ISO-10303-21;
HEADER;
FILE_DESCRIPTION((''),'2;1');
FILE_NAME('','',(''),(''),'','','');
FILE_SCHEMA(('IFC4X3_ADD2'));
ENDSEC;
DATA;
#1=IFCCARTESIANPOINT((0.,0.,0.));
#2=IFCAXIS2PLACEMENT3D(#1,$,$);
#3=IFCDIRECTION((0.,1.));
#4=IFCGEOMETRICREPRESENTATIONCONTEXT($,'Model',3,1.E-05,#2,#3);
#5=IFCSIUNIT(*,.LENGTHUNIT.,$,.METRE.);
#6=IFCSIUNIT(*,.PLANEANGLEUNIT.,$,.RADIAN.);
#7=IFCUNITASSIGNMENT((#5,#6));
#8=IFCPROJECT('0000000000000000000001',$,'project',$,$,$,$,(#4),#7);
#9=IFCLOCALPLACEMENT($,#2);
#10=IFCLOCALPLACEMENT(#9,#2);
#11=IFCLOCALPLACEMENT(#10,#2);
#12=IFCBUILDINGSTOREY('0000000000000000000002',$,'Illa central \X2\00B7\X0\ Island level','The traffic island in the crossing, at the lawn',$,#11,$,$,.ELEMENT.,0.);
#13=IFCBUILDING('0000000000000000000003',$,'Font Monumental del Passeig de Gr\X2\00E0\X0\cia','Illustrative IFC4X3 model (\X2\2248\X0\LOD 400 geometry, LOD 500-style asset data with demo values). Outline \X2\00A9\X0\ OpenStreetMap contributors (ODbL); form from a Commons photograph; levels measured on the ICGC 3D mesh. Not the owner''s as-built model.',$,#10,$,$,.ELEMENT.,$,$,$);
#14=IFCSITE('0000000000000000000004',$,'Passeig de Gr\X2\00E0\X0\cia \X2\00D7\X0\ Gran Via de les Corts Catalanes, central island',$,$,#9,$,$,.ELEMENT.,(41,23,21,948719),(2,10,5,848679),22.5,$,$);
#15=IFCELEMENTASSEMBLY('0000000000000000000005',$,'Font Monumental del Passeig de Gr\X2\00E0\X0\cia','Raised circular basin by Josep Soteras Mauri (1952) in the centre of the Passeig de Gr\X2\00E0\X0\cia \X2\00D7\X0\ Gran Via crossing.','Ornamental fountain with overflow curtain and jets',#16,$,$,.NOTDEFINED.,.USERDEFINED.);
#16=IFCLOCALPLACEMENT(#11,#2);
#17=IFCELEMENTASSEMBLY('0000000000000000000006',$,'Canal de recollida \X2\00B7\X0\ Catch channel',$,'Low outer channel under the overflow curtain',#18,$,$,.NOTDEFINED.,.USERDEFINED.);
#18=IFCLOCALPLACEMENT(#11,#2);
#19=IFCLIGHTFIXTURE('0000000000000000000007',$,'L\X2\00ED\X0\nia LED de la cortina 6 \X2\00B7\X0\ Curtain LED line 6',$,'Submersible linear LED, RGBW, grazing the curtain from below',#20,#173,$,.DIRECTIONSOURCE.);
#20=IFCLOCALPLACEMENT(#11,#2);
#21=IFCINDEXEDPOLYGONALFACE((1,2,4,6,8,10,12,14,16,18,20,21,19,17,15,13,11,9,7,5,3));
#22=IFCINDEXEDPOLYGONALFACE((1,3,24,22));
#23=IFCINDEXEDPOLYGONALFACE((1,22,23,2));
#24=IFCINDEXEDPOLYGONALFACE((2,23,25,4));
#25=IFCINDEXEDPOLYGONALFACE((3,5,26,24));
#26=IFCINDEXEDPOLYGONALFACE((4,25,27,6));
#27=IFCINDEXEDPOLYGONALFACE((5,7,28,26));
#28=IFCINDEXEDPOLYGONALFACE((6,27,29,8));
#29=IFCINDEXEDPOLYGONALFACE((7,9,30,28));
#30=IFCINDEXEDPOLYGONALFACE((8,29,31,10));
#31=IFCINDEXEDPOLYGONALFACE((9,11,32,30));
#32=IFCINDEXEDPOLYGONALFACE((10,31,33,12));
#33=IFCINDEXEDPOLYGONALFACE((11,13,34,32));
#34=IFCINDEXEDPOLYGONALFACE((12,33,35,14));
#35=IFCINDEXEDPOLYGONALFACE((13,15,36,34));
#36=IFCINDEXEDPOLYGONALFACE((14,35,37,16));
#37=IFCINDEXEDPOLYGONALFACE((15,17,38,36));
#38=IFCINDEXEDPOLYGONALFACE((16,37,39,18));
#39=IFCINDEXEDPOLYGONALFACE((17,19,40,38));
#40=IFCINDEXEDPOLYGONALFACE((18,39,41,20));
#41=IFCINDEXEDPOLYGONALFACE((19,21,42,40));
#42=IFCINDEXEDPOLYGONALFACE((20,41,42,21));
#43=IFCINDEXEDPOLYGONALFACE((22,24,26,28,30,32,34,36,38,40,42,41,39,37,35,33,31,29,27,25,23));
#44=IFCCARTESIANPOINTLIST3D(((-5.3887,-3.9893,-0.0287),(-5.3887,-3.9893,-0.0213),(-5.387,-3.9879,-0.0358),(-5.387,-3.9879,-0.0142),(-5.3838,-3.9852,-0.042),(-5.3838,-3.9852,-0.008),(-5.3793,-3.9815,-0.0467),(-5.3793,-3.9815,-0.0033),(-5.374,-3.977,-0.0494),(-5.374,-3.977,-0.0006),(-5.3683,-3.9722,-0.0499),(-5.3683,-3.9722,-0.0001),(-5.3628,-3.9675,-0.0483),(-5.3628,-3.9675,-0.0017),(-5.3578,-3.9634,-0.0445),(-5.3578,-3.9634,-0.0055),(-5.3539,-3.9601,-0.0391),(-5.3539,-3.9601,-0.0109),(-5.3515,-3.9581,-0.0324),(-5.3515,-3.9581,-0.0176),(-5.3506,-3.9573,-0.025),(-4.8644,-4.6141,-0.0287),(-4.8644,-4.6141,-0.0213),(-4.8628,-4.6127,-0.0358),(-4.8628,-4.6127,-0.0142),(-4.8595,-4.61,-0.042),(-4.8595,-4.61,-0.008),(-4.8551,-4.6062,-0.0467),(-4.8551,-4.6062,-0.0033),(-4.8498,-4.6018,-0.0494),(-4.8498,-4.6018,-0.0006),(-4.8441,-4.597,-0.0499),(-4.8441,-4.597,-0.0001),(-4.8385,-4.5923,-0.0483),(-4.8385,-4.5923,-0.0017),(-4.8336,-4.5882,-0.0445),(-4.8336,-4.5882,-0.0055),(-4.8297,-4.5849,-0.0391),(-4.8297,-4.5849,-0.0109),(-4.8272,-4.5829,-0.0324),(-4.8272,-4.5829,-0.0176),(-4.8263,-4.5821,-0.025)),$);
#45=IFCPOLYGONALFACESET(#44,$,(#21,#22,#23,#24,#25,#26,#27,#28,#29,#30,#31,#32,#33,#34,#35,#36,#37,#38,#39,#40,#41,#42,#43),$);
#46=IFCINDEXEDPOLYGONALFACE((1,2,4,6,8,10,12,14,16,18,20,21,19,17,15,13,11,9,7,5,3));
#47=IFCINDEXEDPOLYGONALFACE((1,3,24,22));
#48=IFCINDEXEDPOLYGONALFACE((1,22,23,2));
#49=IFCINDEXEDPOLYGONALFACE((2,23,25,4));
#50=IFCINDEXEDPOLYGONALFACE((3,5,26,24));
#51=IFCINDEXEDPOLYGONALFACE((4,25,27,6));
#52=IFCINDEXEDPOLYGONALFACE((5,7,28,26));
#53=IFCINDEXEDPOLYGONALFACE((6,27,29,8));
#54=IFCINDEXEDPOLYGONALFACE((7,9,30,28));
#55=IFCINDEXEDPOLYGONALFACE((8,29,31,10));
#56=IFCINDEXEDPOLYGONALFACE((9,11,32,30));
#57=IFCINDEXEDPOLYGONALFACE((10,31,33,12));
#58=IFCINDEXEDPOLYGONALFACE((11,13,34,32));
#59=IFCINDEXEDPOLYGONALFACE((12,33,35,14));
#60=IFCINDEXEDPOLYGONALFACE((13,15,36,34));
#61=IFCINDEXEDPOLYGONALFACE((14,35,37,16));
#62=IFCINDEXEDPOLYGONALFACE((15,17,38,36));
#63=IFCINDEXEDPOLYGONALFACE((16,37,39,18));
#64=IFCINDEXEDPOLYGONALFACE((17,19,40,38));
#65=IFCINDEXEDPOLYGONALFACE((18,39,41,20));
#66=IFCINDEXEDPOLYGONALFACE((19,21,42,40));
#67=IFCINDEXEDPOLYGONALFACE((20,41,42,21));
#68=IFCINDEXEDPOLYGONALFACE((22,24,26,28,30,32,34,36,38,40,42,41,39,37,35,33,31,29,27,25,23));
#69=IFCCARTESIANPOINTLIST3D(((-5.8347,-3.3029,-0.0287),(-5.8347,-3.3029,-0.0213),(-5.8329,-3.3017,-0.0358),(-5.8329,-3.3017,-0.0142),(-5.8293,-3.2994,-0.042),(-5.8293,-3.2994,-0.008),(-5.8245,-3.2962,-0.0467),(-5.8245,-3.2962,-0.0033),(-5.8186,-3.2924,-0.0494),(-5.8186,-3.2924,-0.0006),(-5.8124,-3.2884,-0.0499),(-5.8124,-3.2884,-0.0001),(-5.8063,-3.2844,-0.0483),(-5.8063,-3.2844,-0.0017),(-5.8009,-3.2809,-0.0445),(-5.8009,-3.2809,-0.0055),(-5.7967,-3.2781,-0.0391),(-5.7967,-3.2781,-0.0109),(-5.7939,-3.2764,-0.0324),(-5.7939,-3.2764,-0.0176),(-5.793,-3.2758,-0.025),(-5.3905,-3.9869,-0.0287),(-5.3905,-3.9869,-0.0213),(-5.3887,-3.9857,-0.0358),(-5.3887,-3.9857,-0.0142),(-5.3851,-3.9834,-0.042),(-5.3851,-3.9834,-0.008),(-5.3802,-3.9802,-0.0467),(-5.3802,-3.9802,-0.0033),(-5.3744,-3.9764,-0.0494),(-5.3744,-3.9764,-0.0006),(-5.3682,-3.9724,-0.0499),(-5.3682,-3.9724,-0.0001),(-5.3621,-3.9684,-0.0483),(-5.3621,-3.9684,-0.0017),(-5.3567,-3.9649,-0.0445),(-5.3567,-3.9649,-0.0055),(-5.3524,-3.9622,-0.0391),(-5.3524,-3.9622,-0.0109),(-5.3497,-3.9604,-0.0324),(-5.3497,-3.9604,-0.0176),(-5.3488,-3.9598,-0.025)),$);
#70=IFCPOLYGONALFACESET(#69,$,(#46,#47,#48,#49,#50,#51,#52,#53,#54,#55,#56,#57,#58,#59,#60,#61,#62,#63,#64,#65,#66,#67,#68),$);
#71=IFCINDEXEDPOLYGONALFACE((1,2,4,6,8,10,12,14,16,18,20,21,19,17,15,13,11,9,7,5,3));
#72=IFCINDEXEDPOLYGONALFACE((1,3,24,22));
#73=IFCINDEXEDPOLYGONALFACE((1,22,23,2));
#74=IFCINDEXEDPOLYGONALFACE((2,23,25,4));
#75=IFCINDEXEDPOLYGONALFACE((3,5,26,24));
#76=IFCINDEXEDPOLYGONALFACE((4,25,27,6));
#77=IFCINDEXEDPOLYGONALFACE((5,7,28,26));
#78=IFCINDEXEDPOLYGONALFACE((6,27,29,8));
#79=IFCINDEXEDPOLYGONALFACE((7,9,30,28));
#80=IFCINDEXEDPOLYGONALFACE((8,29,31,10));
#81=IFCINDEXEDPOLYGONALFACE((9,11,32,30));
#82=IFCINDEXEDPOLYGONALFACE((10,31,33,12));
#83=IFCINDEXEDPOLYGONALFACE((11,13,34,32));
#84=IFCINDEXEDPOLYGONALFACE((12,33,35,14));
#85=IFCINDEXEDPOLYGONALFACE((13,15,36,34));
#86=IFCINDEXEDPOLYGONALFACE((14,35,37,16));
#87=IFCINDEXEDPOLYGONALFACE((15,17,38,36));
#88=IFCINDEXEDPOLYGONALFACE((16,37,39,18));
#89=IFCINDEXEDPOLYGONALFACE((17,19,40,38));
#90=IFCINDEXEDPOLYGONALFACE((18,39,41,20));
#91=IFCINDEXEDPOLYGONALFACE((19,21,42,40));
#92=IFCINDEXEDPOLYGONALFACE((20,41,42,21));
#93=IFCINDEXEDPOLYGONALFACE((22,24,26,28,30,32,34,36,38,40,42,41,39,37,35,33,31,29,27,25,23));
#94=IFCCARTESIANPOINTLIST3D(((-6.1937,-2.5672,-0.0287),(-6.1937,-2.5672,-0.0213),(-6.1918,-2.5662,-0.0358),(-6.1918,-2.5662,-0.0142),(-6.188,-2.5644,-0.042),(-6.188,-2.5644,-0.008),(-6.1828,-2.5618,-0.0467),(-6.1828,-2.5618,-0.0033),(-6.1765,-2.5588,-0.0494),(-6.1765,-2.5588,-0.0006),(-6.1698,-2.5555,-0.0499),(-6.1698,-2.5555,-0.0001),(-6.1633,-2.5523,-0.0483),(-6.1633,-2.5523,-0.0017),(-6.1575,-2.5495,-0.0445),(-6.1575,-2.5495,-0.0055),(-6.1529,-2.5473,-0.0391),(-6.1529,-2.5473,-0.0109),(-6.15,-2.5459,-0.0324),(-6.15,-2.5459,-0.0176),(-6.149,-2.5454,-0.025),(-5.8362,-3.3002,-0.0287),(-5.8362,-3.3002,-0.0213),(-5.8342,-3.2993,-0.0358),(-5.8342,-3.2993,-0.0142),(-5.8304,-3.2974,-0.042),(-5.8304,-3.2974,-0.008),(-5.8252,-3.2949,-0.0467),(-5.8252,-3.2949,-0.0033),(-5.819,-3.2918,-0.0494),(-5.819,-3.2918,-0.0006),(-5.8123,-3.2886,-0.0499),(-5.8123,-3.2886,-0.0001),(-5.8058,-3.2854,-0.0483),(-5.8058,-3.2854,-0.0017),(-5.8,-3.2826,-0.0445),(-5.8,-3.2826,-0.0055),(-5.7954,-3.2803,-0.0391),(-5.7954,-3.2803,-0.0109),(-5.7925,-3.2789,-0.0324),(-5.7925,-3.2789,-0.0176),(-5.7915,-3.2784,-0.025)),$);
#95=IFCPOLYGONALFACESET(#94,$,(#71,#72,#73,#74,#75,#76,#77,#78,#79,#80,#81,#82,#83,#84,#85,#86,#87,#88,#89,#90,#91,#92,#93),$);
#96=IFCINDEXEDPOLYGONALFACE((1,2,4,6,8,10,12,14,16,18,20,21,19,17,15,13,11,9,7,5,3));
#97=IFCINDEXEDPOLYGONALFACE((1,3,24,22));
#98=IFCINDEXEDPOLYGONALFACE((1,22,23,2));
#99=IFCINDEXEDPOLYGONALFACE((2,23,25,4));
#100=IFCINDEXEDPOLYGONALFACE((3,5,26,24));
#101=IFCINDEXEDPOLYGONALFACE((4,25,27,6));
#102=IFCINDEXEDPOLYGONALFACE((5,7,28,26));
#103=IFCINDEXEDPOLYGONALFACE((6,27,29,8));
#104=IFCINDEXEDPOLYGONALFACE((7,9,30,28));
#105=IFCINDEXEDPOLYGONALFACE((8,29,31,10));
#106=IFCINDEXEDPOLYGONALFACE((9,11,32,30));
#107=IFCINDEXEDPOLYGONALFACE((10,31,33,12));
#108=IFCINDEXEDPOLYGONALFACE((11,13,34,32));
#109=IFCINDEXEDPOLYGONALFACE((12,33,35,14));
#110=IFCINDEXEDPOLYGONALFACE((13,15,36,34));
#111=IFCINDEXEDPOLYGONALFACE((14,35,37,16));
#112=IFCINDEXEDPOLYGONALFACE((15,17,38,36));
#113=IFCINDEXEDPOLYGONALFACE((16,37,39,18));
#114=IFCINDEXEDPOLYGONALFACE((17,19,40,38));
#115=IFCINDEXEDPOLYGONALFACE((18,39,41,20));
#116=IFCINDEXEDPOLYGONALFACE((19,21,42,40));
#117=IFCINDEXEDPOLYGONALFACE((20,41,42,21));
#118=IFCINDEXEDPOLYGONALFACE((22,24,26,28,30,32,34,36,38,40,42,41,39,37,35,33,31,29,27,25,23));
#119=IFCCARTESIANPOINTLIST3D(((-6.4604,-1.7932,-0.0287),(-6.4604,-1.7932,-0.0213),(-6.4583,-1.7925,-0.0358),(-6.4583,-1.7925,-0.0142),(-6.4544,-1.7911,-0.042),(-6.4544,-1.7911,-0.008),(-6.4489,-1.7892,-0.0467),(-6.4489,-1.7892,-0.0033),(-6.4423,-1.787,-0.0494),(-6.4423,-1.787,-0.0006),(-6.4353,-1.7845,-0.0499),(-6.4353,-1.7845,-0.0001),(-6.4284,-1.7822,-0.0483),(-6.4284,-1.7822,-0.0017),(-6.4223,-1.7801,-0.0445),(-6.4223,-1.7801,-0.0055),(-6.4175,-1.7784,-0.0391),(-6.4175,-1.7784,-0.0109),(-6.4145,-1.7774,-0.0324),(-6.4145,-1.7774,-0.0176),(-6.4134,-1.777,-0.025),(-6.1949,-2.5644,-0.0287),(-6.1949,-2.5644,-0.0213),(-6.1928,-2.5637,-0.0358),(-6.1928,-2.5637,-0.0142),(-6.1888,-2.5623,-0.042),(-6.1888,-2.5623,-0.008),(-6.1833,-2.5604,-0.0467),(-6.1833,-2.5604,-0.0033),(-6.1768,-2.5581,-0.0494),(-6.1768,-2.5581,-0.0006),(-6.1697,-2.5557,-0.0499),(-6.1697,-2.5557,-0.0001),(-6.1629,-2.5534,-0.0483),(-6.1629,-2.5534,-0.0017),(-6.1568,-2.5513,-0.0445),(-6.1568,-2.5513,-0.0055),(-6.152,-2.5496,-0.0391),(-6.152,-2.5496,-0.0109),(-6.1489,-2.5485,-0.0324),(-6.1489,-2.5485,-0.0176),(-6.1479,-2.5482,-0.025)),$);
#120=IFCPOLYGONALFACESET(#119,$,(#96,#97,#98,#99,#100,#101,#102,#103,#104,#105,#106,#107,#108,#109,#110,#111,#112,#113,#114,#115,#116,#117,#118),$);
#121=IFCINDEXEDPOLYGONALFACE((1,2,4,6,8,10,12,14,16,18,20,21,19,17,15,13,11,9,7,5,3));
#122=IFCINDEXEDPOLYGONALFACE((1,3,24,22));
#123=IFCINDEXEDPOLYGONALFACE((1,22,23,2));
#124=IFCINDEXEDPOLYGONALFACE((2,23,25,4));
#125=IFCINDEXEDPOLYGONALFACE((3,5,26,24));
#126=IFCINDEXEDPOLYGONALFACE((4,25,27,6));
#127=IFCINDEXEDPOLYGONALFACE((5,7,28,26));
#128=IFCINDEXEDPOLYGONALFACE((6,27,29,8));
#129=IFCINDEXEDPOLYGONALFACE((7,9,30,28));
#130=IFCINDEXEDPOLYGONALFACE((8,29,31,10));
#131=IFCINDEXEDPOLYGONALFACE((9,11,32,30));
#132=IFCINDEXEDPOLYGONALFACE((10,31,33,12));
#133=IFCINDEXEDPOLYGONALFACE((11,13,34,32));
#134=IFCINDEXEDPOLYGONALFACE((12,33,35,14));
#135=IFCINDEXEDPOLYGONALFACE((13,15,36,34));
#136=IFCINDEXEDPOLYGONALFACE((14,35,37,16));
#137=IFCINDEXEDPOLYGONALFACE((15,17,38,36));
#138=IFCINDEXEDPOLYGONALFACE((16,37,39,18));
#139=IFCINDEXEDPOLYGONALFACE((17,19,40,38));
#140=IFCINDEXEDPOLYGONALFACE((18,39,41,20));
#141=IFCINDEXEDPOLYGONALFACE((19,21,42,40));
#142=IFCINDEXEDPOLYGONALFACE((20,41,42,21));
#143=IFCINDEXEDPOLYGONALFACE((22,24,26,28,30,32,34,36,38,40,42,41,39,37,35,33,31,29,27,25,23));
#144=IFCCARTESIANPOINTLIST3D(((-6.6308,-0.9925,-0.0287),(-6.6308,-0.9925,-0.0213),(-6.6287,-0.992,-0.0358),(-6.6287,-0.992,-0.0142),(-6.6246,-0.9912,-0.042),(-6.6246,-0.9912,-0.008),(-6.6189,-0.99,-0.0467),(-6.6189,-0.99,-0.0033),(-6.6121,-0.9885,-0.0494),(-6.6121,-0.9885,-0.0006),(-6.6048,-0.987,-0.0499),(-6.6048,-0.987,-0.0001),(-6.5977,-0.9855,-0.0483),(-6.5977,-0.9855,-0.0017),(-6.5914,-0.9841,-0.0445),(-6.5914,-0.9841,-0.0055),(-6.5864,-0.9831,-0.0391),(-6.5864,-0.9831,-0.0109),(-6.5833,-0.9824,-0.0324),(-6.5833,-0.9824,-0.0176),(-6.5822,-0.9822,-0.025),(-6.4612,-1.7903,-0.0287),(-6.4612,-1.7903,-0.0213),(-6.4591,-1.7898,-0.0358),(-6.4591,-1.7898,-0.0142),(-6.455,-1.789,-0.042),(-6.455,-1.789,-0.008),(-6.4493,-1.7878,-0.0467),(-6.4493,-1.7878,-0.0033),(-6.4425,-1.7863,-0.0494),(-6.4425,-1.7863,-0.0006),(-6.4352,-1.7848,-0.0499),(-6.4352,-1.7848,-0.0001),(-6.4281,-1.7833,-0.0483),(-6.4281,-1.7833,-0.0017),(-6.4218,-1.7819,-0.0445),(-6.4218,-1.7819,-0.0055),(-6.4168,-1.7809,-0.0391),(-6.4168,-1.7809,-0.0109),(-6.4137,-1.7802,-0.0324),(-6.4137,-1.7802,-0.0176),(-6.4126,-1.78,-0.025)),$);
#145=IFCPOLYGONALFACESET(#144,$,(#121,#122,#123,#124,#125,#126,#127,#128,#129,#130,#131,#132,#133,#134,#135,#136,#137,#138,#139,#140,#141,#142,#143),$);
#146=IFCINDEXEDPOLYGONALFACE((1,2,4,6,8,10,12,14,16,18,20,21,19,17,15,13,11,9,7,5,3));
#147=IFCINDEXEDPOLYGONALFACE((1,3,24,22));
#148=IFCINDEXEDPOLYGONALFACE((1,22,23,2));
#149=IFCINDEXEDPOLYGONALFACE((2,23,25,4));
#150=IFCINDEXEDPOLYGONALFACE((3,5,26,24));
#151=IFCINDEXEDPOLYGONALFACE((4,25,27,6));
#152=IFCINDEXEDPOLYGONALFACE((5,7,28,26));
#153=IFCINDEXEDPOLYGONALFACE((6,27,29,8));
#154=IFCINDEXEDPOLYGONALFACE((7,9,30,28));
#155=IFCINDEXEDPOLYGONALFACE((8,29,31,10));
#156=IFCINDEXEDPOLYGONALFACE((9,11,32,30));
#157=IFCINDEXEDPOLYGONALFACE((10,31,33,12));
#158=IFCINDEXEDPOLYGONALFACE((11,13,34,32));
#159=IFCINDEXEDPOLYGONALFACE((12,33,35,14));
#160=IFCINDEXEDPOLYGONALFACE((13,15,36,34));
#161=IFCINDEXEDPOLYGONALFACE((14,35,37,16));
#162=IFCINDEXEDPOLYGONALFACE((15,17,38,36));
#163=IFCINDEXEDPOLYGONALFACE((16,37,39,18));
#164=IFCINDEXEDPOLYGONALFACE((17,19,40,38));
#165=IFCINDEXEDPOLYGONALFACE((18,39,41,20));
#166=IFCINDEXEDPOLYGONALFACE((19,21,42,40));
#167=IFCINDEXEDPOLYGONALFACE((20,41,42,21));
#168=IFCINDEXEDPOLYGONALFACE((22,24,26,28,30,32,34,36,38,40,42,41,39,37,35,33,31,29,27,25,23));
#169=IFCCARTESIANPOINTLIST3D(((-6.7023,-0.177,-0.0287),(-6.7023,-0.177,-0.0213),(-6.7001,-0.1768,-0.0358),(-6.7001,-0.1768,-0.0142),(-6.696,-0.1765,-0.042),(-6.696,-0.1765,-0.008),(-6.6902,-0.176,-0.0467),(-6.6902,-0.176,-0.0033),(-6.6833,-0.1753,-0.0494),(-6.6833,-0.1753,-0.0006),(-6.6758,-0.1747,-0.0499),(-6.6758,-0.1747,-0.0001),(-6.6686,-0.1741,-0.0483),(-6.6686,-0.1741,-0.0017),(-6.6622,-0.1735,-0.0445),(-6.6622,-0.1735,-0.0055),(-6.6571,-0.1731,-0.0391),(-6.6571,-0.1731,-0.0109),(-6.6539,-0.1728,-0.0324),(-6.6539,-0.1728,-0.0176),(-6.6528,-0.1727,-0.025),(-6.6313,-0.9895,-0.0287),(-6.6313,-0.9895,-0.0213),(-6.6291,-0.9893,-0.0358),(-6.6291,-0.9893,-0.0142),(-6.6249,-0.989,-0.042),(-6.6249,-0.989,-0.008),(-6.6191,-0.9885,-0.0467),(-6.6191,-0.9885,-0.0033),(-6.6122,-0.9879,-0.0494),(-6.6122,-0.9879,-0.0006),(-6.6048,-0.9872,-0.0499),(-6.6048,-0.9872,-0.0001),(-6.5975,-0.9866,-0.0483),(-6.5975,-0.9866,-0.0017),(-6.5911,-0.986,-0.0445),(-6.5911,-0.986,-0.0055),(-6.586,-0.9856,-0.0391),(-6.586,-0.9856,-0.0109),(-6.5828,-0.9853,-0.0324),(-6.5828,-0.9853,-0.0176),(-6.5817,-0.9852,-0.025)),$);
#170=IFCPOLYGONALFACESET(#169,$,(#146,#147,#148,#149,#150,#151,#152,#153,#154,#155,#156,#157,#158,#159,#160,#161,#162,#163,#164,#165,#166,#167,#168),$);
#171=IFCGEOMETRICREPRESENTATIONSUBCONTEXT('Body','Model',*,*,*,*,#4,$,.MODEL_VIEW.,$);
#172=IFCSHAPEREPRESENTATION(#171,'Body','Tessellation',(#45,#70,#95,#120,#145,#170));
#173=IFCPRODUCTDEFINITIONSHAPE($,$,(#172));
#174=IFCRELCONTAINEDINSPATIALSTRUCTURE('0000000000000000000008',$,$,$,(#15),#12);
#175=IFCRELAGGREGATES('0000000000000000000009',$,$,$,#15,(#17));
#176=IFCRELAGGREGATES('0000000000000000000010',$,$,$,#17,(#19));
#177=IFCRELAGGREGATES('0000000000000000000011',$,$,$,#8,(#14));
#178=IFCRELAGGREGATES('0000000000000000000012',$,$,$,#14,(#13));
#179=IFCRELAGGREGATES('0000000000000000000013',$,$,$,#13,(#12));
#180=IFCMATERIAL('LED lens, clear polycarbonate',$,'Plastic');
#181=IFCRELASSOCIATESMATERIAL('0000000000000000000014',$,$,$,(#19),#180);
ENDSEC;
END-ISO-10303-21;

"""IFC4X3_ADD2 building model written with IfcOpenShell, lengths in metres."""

from ifc_helpers import new_model, si_unit, direction, frame, origin, origin_2d_with_axis, place, context, subcontext, project, spatial, circle, extrude, material, element, aggregate, save


model = new_model("IFC4X3_ADD2")

# Units and contexts
model_context = context("Model", 3, precision=1e-05, world=origin(), true_north=direction((0.0, 1.0)))
body_context = subcontext(model_context, "Body", "Model", "MODEL_VIEW")
ifc_project = project(units=[si_unit("LENGTHUNIT", "METRE"), si_unit("PLANEANGLEUNIT", "RADIAN")], contexts=[model_context])

# Site, building, storey
site_placement = place(None, origin())
site = spatial("IfcSite", under=ifc_project, at=site_placement, Name="Passeig de Gràcia × Gran Via de les Corts Catalanes, central island", CompositionType="ELEMENT", RefLatitude=(41, 23, 21, 948719), RefLongitude=(2, 10, 5, 848679), RefElevation=22.5)
building_placement = place(site_placement, origin())
building = spatial("IfcBuilding", under=site, at=building_placement, Name="Font Monumental del Passeig de Gràcia", Description="Illustrative IFC4X3 model (≈LOD 400 geometry, LOD 500-style asset data with demo values). Outline © OpenStreetMap contributors (ODbL); form from a Commons photograph; levels measured on the ICGC 3D mesh. Not the owner's as-built model.", CompositionType="ELEMENT")
storey_placement = place(building_placement, origin())
storey = spatial("IfcBuildingStorey", under=building, at=storey_placement, Name="Illa central · Island level", Description="The traffic island in the crossing, at the lawn", CompositionType="ELEMENT", Elevation=0.0)

# Element assemblies, light fixture
assembly_1_placement = place(building_placement, origin())
assembly_1 = element("IfcElementAssembly", 1, at=assembly_1_placement, inside=storey, Name="Font Monumental del Passeig de Gràcia", Description="Raised circular basin by Josep Soteras Mauri (1952) in the centre of the Passeig de Gràcia × Gran Via crossing.", ObjectType="Ornamental fountain with overflow curtain and jets", AssemblyPlace="NOTDEFINED", PredefinedType="USERDEFINED")
assembly_2_placement = place(building_placement, origin())
assembly_2 = element("IfcElementAssembly", 2, at=assembly_2_placement, Name="Canal de recollida · Catch channel", ObjectType="Low outer channel under the overflow curtain", AssemblyPlace="NOTDEFINED", PredefinedType="USERDEFINED")
ifc_material_1 = material(Name="LED lens, clear polycarbonate", Category="Plastic")
light_fixture_1_placement = place(building_placement, origin())
light_fixture_1 = element("IfcLightFixture", 3, at=light_fixture_1_placement, material=ifc_material_1, Name="Línia LED de la cortina 6 · Curtain LED line 6", ObjectType="Submersible linear LED, RGBW, grazing the curtain from below", PredefinedType="DIRECTIONSOURCE", context=body_context, shape_type="SweptSolid", body=[
    extrude(circle(Radius=0.025, at=origin_2d_with_axis()), frame((-4.8455, -4.5982, -0.025), z_axis=(-0.642788, 0.766044, 0.0), x_axis=(0.766044, 0.642788, 0.0)), (0.0, 0.0, 1.0), 0.8156),
    extrude(circle(Radius=0.025, at=origin_2d_with_axis()), frame((-5.3698, -3.9734, -0.025), z_axis=(-0.544639, 0.838671, 0.0), x_axis=(0.838671, 0.544639, 0.0)), (0.0, 0.0, 1.0), 0.8156),
    extrude(circle(Radius=0.025, at=origin_2d_with_axis()), frame((-5.814, -3.2894, -0.025), z_axis=(-0.438371, 0.898794, 0.0), x_axis=(0.898794, 0.438371, 0.0)), (0.0, 0.0, 1.0), 0.8156),
    extrude(circle(Radius=0.025, at=origin_2d_with_axis()), frame((-6.1715, -2.5563, -0.025), z_axis=(-0.325568, 0.945519, 0.0), x_axis=(0.945519, 0.325568, 0.0)), (0.0, 0.0, 1.0), 0.8156),
    extrude(circle(Radius=0.025, at=origin_2d_with_axis()), frame((-6.4371, -1.7852, -0.025), z_axis=(-0.207912, 0.978148, 0.0), x_axis=(0.978148, 0.207912, 0.0)), (0.0, 0.0, 1.0), 0.8156),
    extrude(circle(Radius=0.025, at=origin_2d_with_axis()), frame((-6.6066, -0.9874, -0.025), z_axis=(-0.087156, 0.996195, 0.0), x_axis=(0.996195, 0.087156, 0.0)), (0.0, 0.0, 1.0), 0.8156),
])
aggregate(assembly_1, [assembly_2])
aggregate(assembly_2, [light_fixture_1])

save(model, "model.ifc")
